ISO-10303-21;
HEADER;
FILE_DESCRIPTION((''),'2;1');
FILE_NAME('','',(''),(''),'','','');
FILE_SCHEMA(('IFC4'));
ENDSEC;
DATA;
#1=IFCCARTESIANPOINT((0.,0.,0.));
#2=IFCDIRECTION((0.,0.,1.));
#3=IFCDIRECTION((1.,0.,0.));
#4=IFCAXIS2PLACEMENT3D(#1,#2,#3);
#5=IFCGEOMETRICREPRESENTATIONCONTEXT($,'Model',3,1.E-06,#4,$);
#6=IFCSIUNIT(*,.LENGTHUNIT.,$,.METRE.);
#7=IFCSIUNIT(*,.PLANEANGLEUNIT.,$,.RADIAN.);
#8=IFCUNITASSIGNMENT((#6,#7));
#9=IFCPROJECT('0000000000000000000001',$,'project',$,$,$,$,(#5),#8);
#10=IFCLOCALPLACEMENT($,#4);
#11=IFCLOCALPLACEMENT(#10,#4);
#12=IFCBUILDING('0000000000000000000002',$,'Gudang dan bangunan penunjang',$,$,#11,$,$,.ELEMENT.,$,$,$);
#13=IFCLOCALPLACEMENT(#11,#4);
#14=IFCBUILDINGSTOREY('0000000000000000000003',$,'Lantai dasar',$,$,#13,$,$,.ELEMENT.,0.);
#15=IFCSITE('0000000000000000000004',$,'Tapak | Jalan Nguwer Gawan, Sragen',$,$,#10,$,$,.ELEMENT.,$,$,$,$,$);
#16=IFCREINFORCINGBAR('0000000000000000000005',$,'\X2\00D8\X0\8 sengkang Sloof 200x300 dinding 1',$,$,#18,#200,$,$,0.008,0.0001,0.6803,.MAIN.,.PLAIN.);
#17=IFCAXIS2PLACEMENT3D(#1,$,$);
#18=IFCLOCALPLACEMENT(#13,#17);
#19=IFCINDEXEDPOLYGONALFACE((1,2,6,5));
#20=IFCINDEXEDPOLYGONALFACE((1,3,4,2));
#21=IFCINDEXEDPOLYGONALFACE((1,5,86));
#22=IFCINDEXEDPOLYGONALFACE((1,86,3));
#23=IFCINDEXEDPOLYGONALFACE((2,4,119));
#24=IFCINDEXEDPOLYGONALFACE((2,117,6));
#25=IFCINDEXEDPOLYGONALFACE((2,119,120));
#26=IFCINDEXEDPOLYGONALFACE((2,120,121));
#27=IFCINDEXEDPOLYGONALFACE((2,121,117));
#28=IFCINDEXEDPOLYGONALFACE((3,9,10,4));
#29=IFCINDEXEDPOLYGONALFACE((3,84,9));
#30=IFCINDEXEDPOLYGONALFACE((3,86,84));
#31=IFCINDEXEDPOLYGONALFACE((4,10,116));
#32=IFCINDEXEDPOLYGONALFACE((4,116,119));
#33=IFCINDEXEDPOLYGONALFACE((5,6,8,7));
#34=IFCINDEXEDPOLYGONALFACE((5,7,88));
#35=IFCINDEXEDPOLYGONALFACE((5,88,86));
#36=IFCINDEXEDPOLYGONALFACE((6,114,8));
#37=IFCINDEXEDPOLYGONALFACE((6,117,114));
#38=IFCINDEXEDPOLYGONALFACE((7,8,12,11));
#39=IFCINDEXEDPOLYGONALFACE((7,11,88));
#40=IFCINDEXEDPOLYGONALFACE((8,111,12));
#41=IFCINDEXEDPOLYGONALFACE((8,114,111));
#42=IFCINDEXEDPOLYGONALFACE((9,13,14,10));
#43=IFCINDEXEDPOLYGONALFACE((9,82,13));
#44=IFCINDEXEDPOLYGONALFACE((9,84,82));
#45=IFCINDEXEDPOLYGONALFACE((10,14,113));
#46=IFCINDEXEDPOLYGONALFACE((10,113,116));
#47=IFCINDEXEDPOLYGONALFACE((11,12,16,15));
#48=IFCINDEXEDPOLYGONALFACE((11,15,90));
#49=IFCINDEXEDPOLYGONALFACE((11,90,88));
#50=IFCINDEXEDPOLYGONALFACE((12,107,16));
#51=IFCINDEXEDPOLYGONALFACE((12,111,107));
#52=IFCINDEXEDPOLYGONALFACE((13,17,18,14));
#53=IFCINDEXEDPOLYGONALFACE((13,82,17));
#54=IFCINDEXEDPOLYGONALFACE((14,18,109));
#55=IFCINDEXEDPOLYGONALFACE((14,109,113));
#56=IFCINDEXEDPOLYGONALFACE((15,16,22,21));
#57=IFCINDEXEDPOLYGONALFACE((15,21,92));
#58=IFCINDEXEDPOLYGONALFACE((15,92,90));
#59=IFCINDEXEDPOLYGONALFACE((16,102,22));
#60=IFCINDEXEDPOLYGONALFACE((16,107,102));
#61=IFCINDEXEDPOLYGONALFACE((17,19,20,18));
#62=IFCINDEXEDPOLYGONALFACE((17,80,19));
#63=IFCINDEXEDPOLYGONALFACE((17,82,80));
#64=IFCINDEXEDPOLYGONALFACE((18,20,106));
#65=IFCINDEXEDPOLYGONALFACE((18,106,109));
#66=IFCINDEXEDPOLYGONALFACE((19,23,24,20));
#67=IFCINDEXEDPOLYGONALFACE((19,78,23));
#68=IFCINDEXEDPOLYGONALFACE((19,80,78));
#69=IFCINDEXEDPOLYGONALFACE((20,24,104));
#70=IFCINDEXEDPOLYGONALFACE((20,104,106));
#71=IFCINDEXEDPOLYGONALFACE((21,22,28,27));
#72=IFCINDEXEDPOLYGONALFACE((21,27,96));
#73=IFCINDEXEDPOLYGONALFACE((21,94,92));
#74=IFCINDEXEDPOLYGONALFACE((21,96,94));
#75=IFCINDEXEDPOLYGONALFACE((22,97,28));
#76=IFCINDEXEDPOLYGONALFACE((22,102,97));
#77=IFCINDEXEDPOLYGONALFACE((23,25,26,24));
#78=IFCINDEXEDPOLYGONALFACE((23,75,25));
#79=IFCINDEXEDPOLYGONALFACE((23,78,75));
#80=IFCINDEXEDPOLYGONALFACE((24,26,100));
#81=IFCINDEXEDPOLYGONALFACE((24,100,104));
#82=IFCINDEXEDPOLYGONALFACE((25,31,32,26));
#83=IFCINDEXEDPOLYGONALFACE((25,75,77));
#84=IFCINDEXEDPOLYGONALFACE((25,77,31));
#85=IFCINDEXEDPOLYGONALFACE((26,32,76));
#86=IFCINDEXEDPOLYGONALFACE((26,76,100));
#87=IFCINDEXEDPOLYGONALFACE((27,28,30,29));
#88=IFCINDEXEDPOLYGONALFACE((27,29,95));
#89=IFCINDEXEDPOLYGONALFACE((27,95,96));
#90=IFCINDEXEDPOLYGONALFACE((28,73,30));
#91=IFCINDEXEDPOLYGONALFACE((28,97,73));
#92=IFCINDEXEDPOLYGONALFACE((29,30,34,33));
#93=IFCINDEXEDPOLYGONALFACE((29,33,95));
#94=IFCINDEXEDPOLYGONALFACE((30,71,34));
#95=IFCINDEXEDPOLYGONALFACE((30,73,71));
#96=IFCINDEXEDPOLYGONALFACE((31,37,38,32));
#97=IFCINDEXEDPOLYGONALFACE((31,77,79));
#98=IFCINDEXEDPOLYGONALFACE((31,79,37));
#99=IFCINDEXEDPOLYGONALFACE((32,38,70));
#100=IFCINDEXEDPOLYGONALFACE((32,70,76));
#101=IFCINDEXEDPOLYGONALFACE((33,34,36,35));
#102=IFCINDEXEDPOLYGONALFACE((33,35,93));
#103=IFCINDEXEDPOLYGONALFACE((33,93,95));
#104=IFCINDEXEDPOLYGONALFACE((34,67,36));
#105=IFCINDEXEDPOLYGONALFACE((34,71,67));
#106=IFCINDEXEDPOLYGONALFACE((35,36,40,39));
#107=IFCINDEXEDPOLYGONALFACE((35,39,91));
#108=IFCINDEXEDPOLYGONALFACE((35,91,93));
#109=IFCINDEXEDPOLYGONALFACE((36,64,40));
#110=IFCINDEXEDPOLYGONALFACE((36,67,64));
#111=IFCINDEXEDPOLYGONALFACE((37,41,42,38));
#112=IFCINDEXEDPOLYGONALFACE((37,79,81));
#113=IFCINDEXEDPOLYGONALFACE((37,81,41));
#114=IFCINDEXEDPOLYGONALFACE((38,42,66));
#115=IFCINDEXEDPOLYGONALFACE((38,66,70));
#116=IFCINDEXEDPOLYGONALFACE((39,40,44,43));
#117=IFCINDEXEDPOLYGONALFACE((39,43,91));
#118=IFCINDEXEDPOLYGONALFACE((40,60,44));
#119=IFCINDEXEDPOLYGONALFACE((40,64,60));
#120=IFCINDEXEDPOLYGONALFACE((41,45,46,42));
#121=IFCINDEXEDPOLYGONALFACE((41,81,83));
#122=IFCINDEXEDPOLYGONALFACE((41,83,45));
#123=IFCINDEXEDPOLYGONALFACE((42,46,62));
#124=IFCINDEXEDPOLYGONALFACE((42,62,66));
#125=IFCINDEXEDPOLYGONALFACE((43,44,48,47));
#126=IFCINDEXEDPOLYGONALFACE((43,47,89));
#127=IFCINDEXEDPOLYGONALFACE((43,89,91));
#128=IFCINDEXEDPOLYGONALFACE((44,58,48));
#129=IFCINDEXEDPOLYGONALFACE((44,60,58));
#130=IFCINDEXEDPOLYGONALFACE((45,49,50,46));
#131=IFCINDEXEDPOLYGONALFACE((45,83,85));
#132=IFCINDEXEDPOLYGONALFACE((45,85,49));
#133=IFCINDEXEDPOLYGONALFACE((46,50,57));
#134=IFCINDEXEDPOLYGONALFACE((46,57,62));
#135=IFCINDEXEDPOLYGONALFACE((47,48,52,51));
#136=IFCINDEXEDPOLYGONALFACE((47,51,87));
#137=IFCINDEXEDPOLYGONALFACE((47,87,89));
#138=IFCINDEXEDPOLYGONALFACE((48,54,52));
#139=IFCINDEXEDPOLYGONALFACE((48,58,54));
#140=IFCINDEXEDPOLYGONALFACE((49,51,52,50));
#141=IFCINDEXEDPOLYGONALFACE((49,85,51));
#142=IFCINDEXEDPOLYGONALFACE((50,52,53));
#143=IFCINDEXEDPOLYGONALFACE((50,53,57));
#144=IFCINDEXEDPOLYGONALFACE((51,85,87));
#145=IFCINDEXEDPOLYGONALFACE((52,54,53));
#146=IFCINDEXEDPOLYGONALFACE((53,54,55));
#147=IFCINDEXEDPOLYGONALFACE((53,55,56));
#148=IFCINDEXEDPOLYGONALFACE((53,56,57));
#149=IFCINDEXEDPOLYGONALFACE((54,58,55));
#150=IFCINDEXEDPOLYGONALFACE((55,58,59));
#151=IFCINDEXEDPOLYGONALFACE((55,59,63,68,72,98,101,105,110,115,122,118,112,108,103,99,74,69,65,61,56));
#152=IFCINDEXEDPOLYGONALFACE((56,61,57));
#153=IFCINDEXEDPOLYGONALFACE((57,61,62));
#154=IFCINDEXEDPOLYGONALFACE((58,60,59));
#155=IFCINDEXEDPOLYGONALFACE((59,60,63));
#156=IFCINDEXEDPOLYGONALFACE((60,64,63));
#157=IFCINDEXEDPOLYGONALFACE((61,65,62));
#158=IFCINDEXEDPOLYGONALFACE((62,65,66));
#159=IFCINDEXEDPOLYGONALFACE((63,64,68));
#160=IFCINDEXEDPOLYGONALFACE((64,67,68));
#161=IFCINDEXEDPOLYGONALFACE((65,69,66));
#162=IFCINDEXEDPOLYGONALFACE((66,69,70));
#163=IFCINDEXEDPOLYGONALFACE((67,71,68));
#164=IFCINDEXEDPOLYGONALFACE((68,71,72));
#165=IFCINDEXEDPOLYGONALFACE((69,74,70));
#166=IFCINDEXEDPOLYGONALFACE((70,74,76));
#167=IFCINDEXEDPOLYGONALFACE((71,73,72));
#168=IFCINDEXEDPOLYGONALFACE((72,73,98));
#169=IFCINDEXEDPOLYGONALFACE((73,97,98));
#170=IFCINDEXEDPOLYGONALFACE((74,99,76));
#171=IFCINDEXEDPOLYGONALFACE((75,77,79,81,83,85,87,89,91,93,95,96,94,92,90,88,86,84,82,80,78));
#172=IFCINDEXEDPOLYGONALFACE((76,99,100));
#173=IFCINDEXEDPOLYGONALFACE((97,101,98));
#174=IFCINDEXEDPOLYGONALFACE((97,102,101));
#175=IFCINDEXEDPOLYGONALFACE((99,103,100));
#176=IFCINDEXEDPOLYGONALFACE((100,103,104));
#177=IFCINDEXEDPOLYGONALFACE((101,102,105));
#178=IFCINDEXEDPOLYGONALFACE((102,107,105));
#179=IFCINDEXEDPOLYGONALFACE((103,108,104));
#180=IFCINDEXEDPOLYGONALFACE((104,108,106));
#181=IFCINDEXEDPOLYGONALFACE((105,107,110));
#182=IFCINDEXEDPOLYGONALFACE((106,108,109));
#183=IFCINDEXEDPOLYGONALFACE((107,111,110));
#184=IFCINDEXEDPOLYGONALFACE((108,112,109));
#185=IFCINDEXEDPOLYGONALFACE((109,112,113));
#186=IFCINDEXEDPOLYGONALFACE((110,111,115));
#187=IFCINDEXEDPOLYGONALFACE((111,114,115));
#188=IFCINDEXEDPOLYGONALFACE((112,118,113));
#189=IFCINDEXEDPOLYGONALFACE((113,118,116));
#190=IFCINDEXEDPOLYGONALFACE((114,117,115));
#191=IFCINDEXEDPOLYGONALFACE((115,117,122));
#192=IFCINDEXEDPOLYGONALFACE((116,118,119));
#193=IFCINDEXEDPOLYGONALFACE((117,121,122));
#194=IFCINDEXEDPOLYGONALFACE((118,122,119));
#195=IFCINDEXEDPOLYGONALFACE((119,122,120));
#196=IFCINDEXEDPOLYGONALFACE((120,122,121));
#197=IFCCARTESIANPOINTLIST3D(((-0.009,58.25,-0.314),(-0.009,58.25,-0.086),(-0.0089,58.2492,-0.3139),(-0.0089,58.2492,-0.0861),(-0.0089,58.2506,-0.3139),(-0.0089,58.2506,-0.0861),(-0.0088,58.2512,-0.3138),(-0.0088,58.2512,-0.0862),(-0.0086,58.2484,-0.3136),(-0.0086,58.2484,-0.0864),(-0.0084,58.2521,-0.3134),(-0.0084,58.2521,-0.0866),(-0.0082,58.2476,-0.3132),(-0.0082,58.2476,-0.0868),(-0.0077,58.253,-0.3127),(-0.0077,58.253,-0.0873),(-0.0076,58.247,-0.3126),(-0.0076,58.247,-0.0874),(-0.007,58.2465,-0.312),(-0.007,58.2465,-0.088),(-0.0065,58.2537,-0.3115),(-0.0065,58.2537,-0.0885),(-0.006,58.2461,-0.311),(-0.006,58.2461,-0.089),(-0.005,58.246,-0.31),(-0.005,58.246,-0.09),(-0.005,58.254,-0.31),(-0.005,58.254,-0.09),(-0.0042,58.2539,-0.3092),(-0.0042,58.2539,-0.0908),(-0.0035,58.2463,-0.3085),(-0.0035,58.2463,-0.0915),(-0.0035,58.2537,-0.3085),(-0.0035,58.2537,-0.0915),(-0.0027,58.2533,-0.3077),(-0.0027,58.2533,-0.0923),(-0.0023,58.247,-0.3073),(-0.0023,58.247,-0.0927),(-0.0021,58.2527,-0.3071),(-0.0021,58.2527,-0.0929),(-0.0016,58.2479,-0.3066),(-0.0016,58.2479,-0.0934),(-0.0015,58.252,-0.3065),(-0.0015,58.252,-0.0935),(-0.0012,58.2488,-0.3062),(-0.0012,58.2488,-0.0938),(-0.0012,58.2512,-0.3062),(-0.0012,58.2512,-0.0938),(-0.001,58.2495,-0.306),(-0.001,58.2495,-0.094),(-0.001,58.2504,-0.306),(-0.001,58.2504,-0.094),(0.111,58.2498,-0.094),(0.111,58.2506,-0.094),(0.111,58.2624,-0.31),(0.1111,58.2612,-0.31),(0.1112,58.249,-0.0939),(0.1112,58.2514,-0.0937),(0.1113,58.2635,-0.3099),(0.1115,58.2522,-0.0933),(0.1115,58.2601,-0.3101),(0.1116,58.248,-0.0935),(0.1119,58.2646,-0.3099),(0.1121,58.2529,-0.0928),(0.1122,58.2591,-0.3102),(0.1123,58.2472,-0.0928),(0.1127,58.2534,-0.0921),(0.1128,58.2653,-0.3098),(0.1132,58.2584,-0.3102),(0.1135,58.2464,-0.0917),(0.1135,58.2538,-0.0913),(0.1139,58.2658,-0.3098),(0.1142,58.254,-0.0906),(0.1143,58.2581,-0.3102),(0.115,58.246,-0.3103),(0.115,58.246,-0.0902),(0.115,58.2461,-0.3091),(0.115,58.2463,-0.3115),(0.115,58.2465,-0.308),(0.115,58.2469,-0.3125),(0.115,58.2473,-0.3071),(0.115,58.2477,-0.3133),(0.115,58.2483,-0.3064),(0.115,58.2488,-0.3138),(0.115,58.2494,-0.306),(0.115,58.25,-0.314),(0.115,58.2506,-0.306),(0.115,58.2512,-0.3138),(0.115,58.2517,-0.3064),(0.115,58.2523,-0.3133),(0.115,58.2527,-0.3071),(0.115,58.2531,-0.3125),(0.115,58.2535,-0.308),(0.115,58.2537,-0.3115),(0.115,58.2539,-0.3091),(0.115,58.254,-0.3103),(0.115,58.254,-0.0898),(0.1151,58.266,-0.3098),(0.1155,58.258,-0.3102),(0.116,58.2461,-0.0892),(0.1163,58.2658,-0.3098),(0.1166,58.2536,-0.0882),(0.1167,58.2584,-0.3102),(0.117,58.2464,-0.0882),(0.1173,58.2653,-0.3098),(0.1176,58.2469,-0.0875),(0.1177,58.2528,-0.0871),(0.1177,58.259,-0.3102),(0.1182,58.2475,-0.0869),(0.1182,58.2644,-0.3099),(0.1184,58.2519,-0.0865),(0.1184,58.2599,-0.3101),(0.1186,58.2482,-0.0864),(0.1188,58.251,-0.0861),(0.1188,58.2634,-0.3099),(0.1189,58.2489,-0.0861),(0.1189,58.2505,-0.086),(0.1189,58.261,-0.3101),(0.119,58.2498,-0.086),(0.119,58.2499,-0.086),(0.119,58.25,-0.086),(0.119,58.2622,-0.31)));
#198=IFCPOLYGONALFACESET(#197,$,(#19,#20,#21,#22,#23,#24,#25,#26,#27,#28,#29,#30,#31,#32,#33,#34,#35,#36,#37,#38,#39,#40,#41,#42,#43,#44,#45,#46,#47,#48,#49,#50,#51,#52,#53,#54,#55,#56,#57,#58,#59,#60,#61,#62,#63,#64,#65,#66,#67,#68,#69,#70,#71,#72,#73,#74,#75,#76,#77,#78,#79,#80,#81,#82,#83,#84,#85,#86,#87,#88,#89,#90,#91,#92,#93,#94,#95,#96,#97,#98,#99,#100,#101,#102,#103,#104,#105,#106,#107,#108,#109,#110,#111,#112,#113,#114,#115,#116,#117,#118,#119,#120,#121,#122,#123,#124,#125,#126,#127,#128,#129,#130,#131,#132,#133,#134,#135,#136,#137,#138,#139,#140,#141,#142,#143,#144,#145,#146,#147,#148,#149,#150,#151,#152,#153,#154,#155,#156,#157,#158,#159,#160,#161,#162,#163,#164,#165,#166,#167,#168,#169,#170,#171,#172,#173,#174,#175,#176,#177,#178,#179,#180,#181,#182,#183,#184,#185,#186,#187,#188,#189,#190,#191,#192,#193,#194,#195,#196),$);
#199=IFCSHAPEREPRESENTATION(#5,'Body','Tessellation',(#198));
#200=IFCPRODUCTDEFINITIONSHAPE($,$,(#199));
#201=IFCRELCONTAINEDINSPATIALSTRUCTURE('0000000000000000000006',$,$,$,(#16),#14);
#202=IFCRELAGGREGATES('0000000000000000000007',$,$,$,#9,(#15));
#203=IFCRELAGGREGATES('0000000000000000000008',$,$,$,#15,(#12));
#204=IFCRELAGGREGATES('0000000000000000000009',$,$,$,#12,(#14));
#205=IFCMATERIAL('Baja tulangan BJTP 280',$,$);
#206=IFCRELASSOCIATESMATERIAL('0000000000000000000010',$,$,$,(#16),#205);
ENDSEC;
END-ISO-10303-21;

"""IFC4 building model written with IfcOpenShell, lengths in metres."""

from ifc_helpers import new_model, entity, si_unit, origin_with_axes, place, context, project, spatial, material, element, save


model = new_model("IFC4")

# Units and contexts
model_context = context("Model", 3, precision=1e-06, world=origin_with_axes())
ifc_project = project(units=[si_unit("LENGTHUNIT", "METRE"), si_unit("PLANEANGLEUNIT", "RADIAN")], contexts=[model_context])

# Site, building, storey
site_placement = place(None, origin_with_axes())
site = spatial("IfcSite", under=ifc_project, at=site_placement, Name="Tapak | Jalan Nguwer Gawan, Sragen", CompositionType="ELEMENT")
building_placement = place(site_placement, origin_with_axes())
building = spatial("IfcBuilding", under=site, at=building_placement, Name="Gudang dan bangunan penunjang", CompositionType="ELEMENT")
storey_placement = place(building_placement, origin_with_axes())
storey = spatial("IfcBuildingStorey", under=building, at=storey_placement, Name="Lantai dasar", CompositionType="ELEMENT", Elevation=0.0)

# Shared definitions
placement = place(None, origin_with_axes())

# Reinforcing bar
ifc_material_1 = material(Name="Baja tulangan BJTP 280")
element("IfcReinforcingBar", 1, at=placement, inside=storey, material=ifc_material_1, Name="Ø8 sengkang Sloof 200x300 dinding 1", BarLength=0.6803, BarSurface="PLAIN", CrossSectionArea=0.0001, NominalDiameter=0.008, PredefinedType="MAIN", context=model_context, shape_type="AdvancedSweptSolid", body=[
    entity("IfcSweptDiskSolid", entity("IfcPolyline", [entity("IfcCartesianPoint", [0.115, 58.25, -0.31]), entity("IfcCartesianPoint", [-0.005, 58.25, -0.31]), entity("IfcCartesianPoint", [-0.005, 58.25, -0.09]), entity("IfcCartesianPoint", [0.115, 58.25, -0.09]), entity("IfcCartesianPoint", [0.115, 58.262, -0.31])]), 0.004),
])

save(model, "model.ifc")
